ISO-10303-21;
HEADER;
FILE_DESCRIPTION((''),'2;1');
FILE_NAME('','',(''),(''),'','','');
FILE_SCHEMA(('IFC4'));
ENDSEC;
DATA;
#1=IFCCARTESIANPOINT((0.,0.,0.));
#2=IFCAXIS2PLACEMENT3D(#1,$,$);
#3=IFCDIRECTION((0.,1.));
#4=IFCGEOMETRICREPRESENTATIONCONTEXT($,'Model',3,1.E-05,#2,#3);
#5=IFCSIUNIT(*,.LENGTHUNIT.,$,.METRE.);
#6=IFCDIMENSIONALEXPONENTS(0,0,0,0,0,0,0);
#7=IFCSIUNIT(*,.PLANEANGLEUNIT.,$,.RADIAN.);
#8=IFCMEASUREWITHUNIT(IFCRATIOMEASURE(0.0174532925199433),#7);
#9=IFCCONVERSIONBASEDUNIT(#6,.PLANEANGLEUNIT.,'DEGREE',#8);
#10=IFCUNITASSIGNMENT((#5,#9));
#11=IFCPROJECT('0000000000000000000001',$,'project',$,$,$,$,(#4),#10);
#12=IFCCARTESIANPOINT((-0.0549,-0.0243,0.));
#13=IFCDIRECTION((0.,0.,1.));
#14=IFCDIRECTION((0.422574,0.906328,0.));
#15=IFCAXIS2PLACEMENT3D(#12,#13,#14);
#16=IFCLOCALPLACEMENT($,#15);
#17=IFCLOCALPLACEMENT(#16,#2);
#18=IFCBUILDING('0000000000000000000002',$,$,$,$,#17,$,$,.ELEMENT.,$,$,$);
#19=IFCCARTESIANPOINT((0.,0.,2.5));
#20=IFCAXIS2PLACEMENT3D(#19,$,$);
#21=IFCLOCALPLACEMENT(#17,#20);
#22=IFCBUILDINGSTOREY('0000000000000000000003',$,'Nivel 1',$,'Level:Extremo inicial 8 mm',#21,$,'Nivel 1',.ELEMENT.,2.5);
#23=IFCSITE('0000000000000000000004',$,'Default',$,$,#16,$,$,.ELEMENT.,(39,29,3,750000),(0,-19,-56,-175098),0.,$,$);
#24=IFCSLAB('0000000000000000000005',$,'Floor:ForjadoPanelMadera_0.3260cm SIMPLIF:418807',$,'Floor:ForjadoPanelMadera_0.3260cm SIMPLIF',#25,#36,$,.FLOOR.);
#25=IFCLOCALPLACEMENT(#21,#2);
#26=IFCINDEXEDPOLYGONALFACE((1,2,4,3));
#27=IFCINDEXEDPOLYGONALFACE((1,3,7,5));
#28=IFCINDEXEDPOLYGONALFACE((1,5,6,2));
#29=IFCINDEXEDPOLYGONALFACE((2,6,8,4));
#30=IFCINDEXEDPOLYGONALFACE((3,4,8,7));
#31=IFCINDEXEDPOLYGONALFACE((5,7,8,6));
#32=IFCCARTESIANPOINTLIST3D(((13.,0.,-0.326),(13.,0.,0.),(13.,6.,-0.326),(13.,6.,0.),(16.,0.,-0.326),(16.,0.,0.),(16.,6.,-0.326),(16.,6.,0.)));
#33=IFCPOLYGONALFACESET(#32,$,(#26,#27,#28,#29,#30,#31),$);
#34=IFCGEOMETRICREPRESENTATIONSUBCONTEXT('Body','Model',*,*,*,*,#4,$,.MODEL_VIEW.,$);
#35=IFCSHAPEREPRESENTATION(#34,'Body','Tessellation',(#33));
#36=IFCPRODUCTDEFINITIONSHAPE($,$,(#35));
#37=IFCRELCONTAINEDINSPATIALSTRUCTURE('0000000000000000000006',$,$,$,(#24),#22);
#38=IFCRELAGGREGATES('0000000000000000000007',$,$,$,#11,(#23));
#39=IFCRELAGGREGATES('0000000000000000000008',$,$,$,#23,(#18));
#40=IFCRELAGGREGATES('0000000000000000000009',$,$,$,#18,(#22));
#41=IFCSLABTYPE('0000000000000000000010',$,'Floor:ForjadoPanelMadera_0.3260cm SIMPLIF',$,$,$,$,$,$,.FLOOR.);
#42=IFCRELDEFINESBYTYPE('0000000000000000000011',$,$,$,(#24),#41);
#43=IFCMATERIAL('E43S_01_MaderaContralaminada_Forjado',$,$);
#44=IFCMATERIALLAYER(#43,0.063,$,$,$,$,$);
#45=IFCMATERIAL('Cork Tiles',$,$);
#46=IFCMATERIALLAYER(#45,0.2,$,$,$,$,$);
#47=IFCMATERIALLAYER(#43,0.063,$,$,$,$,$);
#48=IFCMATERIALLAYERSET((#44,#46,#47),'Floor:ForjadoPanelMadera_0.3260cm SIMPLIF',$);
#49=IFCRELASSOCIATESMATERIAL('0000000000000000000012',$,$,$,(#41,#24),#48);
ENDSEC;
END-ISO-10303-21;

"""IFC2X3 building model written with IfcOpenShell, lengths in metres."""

from ifc_helpers import new_model, entity, si_unit, converted_unit, direction, frame, frame_2d, origin, place, context, subcontext, project, spatial, rectangle, extrude, material, layer, layer_set, layer_usage, type_object, element, save


model = new_model("IFC2X3")

# Units and contexts
model_context = context("Model", 3, precision=1e-05, world=origin(), true_north=direction((0.0, 1.0)))
body_context = subcontext(model_context, "Body", "Model", "MODEL_VIEW")
ifc_project = project(units=[si_unit("LENGTHUNIT", "METRE"), converted_unit("PLANEANGLEUNIT", "DEGREE", entity("IfcRatioMeasure", 0.0174532925199433), si_unit("PLANEANGLEUNIT", "RADIAN"), dimensions=[0, 0, 0, 0, 0, 0, 0])], contexts=[model_context])

# Site, building, storey
site_placement = place(None, frame((-0.0549, -0.0243, 0.0), z_axis=(0.0, 0.0, 1.0), x_axis=(0.422574, 0.906328, 0.0)))
site = spatial("IfcSite", under=ifc_project, at=site_placement, Name="Default", CompositionType="ELEMENT", RefLatitude=(39, 29, 3, 750000), RefLongitude=(0, -19, -56, -175098), RefElevation=0.0)
building_placement = place(site_placement, origin())
building = spatial("IfcBuilding", under=site, at=building_placement, CompositionType="ELEMENT")
storey_placement = place(building_placement, frame((0.0, 0.0, 2.5)))
storey = spatial("IfcBuildingStorey", under=building, at=storey_placement, Name="Nivel 1", ObjectType="Level:Extremo inicial 8 mm", LongName="Nivel 1", CompositionType="ELEMENT", Elevation=2.5)

# Slab
ifc_material_1 = material(Name="E43S_01_MaderaContralaminada_Forjado")
ifc_layer_1 = layer(ifc_material_1, 0.063)
ifc_material_2 = material(Name="Cork Tiles")
ifc_layer_2 = layer(ifc_material_2, 0.2)
ifc_layer_3 = layer(ifc_material_1, 0.063)
ifc_layer_set = layer_set([ifc_layer_1, ifc_layer_2, ifc_layer_3], Name="Floor:ForjadoPanelMadera_0.3260cm SIMPLIF")
ifc_layer_usage = layer_usage(ifc_layer_set, "AXIS3", "POSITIVE", 0.0)
slab_type = type_object("IfcSlabType", Name="Floor:ForjadoPanelMadera_0.3260cm SIMPLIF", PredefinedType="FLOOR", material=ifc_layer_set)
slab_placement = place(storey_placement, origin())
element("IfcSlab", 1, at=slab_placement, inside=storey, type_object=slab_type, material=ifc_layer_usage, Name="Floor:ForjadoPanelMadera_0.3260cm SIMPLIF:418807", ObjectType="Floor:ForjadoPanelMadera_0.3260cm SIMPLIF", PredefinedType="FLOOR", context=body_context, shape_type="SweptSolid", body=[
    extrude(rectangle(XDim=6.0, YDim=3.0, at=frame_2d((0.0, 0.0), x_axis=(1.0, 0.0))), frame((14.5, 3.0, 0.0), z_axis=(0.0, 0.0, -1.0), x_axis=(0.0, 1.0, 0.0)), (0.0, 0.0, 1.0), 0.326),
])

save(model, "model.ifc")
